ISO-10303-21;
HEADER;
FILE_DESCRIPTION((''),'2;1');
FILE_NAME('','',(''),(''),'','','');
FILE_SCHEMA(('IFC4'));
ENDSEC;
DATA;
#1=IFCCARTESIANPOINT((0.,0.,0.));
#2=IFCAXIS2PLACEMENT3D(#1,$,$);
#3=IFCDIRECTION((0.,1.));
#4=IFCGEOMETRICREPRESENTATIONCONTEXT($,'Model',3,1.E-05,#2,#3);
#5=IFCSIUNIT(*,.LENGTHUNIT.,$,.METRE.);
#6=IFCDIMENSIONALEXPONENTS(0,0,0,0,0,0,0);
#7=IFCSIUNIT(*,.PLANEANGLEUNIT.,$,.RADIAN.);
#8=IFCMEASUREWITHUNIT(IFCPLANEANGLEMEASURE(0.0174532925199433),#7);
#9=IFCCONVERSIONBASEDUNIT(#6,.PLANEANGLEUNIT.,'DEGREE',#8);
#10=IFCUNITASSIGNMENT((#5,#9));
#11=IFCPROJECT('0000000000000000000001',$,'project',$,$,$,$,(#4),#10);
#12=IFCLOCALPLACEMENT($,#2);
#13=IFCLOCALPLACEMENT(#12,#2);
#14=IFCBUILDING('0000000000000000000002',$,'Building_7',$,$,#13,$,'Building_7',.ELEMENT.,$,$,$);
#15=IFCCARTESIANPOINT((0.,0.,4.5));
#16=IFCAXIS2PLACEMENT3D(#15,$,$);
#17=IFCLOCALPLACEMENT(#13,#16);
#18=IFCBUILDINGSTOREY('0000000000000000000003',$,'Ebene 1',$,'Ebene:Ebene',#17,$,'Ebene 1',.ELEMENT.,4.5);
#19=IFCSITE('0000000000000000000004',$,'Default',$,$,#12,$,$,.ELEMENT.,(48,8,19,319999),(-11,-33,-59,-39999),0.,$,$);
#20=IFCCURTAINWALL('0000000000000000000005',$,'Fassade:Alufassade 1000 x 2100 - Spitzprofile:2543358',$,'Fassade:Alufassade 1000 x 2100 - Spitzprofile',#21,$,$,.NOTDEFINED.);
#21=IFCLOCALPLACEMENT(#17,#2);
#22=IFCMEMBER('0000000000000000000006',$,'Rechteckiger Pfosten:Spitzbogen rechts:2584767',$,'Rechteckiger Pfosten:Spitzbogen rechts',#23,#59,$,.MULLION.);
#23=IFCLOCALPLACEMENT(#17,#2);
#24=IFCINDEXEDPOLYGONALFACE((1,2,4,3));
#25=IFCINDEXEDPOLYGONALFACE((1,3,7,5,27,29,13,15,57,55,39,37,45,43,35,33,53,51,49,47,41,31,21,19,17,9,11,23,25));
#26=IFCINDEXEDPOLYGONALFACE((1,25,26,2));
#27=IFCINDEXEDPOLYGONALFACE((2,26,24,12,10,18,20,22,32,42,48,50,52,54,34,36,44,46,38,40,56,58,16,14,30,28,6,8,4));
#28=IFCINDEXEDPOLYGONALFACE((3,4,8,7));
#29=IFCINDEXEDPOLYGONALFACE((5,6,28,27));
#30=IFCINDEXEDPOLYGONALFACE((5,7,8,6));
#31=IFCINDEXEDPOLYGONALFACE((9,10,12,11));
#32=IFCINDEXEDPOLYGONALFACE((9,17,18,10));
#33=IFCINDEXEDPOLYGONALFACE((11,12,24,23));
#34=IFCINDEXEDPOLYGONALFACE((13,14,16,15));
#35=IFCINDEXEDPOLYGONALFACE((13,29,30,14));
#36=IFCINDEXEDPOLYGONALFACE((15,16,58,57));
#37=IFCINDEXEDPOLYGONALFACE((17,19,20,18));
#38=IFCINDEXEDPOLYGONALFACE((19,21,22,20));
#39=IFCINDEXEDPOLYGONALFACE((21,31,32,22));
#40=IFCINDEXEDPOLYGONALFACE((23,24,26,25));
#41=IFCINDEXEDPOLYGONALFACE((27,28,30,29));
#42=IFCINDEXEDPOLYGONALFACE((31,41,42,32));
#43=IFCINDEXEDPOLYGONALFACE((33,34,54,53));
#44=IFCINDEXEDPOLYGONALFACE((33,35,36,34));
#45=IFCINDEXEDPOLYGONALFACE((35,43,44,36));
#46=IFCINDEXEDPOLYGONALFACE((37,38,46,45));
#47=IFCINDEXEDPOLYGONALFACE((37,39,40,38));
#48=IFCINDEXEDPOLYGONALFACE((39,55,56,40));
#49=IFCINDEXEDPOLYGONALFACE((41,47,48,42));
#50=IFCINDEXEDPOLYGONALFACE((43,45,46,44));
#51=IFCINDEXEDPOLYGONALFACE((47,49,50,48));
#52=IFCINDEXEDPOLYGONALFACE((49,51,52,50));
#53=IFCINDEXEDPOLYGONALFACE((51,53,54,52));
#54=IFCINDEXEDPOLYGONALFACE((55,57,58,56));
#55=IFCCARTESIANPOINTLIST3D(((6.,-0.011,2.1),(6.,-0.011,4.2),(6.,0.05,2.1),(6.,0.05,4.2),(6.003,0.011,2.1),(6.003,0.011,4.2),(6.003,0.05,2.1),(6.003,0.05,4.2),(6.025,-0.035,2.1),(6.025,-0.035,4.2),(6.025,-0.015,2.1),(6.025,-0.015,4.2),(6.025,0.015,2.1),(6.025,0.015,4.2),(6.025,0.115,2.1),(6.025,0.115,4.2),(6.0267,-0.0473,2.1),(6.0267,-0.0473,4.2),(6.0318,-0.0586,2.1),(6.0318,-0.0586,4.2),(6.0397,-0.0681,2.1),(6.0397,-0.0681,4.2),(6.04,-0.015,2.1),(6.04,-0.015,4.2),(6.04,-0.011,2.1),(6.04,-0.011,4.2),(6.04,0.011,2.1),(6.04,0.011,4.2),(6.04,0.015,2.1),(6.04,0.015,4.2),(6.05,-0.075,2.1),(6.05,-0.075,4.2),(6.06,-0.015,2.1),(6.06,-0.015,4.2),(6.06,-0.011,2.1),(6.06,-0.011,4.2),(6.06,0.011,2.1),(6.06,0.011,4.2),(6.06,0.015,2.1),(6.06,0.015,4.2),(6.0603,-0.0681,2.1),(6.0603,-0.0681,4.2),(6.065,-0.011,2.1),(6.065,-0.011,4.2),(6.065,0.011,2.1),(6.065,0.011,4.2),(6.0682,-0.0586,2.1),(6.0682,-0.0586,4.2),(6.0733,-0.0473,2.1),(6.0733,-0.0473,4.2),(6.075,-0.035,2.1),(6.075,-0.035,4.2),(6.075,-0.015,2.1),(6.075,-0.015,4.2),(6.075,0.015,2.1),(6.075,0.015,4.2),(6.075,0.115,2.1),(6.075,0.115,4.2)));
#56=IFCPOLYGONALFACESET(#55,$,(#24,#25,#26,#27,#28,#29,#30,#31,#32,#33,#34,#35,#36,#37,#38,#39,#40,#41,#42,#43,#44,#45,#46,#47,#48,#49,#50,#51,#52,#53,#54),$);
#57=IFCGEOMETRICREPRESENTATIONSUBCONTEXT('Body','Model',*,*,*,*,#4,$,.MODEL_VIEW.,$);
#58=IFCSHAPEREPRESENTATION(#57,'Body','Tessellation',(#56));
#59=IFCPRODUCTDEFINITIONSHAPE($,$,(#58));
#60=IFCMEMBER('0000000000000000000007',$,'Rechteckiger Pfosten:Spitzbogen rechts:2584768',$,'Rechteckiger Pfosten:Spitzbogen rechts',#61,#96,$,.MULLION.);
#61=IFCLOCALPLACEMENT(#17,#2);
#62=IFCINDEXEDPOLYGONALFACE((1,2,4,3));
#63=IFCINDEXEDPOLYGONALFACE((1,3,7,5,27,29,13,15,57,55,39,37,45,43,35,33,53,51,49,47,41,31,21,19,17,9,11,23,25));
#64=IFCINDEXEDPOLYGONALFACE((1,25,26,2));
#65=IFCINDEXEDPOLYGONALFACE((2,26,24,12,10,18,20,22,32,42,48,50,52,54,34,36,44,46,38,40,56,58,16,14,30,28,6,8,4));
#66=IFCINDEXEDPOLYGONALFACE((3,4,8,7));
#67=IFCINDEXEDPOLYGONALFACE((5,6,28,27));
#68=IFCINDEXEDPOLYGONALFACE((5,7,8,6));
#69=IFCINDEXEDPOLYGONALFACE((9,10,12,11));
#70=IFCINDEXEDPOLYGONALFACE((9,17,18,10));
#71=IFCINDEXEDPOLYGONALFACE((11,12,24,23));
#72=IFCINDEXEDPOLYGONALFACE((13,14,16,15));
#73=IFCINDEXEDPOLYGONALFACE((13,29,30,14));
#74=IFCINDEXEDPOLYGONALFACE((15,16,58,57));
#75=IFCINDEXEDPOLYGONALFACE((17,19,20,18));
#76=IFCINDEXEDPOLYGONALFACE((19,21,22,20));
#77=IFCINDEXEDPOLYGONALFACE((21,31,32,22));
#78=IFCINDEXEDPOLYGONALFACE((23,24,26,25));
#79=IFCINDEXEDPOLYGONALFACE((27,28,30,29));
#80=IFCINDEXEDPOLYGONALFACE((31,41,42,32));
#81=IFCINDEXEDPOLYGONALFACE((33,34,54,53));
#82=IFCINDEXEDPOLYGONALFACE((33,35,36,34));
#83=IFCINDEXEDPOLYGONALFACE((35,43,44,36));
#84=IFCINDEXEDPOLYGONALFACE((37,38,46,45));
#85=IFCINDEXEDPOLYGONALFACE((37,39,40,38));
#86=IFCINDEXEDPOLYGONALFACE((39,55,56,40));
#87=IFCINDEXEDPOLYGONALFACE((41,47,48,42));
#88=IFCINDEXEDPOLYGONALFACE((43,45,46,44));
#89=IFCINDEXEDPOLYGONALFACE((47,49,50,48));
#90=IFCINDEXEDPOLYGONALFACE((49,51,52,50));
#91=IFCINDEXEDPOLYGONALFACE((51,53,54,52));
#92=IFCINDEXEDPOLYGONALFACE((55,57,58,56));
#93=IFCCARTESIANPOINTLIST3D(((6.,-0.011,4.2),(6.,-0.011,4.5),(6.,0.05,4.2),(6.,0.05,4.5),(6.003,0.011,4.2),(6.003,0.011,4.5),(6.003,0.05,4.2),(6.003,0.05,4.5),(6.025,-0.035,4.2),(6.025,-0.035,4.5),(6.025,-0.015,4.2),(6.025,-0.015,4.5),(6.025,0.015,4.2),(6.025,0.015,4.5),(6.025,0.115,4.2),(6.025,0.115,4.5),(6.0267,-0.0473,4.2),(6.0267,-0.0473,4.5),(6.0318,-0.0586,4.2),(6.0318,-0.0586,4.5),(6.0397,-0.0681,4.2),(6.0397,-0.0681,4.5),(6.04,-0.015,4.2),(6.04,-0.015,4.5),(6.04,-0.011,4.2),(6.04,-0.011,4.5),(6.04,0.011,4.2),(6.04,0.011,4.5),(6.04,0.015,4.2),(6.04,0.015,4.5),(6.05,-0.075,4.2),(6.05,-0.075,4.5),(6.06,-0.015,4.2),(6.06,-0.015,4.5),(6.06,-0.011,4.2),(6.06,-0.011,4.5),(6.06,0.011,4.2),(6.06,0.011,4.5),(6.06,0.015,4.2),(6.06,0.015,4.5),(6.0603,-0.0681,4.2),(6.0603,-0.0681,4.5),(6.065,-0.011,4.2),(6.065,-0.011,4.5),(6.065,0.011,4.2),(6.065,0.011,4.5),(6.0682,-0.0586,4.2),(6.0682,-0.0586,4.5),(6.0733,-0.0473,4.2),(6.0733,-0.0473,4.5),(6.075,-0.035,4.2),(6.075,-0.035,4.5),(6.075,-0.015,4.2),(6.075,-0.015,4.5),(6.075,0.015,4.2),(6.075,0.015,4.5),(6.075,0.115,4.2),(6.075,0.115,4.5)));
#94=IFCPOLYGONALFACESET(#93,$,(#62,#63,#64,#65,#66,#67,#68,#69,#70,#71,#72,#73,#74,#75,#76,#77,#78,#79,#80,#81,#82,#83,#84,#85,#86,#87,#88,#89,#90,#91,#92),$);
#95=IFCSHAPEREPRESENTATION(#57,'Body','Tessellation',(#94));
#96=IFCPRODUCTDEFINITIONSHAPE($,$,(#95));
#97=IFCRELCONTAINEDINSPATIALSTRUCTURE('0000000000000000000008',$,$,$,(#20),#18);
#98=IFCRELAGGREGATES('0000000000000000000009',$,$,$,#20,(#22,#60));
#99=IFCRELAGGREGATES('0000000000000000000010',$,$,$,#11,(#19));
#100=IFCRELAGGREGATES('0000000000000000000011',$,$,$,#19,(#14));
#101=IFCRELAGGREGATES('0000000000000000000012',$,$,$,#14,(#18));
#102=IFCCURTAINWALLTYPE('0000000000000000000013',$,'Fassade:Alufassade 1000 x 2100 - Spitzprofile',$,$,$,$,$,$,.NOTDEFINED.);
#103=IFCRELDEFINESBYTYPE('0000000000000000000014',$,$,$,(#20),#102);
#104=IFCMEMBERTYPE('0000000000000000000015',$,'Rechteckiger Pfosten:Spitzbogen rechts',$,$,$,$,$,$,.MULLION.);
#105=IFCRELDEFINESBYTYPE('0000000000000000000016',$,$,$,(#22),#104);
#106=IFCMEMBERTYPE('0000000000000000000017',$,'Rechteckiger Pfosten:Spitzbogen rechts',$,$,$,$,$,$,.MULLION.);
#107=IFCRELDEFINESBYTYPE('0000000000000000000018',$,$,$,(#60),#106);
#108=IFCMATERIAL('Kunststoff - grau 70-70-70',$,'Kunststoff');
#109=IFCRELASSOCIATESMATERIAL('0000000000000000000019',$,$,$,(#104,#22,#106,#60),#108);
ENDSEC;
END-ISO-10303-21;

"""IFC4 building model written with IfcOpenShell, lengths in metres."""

from ifc_helpers import new_model, entity, si_unit, converted_unit, direction, frame, origin, place, context, subcontext, project, spatial, line, arc, indexed_curve, outline, extrude, source, transform, mapped, material, type_object, type_shapes, element, aggregate, save


model = new_model("IFC4")

# Units and contexts
model_context = context("Model", 3, precision=1e-05, world=origin(), true_north=direction((0.0, 1.0)))
body_context = subcontext(model_context, "Body", "Model", "MODEL_VIEW")
ifc_project = project(units=[si_unit("LENGTHUNIT", "METRE"), converted_unit("PLANEANGLEUNIT", "DEGREE", entity("IfcPlaneAngleMeasure", 0.0174532925199433), si_unit("PLANEANGLEUNIT", "RADIAN"), dimensions=[0, 0, 0, 0, 0, 0, 0])], contexts=[model_context])

# Site, building, storey
site_placement = place(None, origin())
site = spatial("IfcSite", under=ifc_project, at=site_placement, Name="Default", CompositionType="ELEMENT", RefLatitude=(48, 8, 19, 319999), RefLongitude=(-11, -33, -59, -39999), RefElevation=0.0)
building_placement = place(site_placement, origin())
building = spatial("IfcBuilding", under=site, at=building_placement, Name="Building_7", LongName="Building_7", CompositionType="ELEMENT")
storey_placement = place(building_placement, frame((0.0, 0.0, 4.5)))
storey = spatial("IfcBuildingStorey", under=building, at=storey_placement, Name="Ebene 1", ObjectType="Ebene:Ebene", LongName="Ebene 1", CompositionType="ELEMENT", Elevation=4.5)

# Curtain wall, members
curtain_wall_type = type_object("IfcCurtainWallType", Name="Fassade:Alufassade 1000 x 2100 - Spitzprofile", PredefinedType="NOTDEFINED")
curtain_wall_placement = place(storey_placement, frame((0.0, 0.0, -4.5)))
curtain_wall = element("IfcCurtainWall", 1, at=curtain_wall_placement, inside=storey, type_object=curtain_wall_type, Name="Fassade:Alufassade 1000 x 2100 - Spitzprofile:2543358", ObjectType="Fassade:Alufassade 1000 x 2100 - Spitzprofile", PredefinedType="NOTDEFINED")
ifc_material = material(Name="Kunststoff - grau 70-70-70", Category="Kunststoff")
member_type_1 = type_object("IfcMemberType", Name="Rechteckiger Pfosten:Spitzbogen rechts", PredefinedType="MULLION", material=ifc_material)
shared_shape_1 = source(origin(), body_context, "Body", "SweptSolid", [
    extrude(outline(indexed_curve([(-0.107, -0.0321), (-0.007, -0.0321), (-0.007, -0.0171), (-0.003, -0.0171), (-0.003, -0.0221), (0.019, -0.0221), (0.019, -0.0171), (0.023, -0.0171), (0.023, -0.0321), (0.043, -0.0321), (0.0666, -0.0254), (0.083, -0.0071), (0.0666, 0.0111), (0.043, 0.0179), (0.023, 0.0179), (0.023, 0.0029), (0.019, 0.0029), (0.019, 0.0429), (-0.042, 0.0429), (-0.042, 0.0399), (-0.003, 0.0399), (-0.003, 0.0029), (-0.007, 0.0029), (-0.007, 0.0179), (-0.107, 0.0179)], segments=[line(1, 2, 3, 4, 5, 6, 7, 8, 9, 10), arc(10, 11, 12), arc(12, 13, 14), line(14, 15, 16, 17, 18, 19, 20, 21, 22, 23, 24, 25, 1)], self_intersect=False)), frame((-0.0429, 0.008, -2.1), z_axis=(0.0, 0.0, 1.0), x_axis=(0.0, -1.0, 0.0)), (0.0, 0.0, 1.0), 2.1),
])
type_shapes(member_type_1, [shared_shape_1])
member_1_placement = place(curtain_wall_placement, frame((6.0, 0.0, 6.6), z_axis=(0.0, 0.0, -1.0), x_axis=(-1.0, 0.0, 0.0)))
member_1 = element("IfcMember", 2, at=member_1_placement, type_object=member_type_1, material=ifc_material, Name="Rechteckiger Pfosten:Spitzbogen rechts:2584767", ObjectType="Rechteckiger Pfosten:Spitzbogen rechts", PredefinedType="MULLION", context=body_context, shape_type="MappedRepresentation", body=[
    mapped(shared_shape_1, transform((0.0, 0.0, 0.0), scale=1.0)),
])
member_type_2 = type_object("IfcMemberType", Name="Rechteckiger Pfosten:Spitzbogen rechts", PredefinedType="MULLION", material=ifc_material)
shared_shape_2 = source(origin(), body_context, "Body", "SweptSolid", [
    extrude(outline(indexed_curve([(-0.107, -0.0321), (-0.007, -0.0321), (-0.007, -0.0171), (-0.003, -0.0171), (-0.003, -0.0221), (0.019, -0.0221), (0.019, -0.0171), (0.023, -0.0171), (0.023, -0.0321), (0.043, -0.0321), (0.0666, -0.0254), (0.083, -0.0071), (0.0666, 0.0111), (0.043, 0.0179), (0.023, 0.0179), (0.023, 0.0029), (0.019, 0.0029), (0.019, 0.0429), (-0.042, 0.0429), (-0.042, 0.0399), (-0.003, 0.0399), (-0.003, 0.0029), (-0.007, 0.0029), (-0.007, 0.0179), (-0.107, 0.0179)], segments=[line(1, 2, 3, 4, 5, 6, 7, 8, 9, 10), arc(10, 11, 12), arc(12, 13, 14), line(14, 15, 16, 17, 18, 19, 20, 21, 22, 23, 24, 25, 1)], self_intersect=False)), frame((-0.0429, 0.008, -0.3), z_axis=(0.0, 0.0, 1.0), x_axis=(0.0, -1.0, 0.0)), (0.0, 0.0, 1.0), 0.3),
])
type_shapes(member_type_2, [shared_shape_2])
member_2_placement = place(curtain_wall_placement, frame((6.0, 0.0, 8.7), z_axis=(0.0, 0.0, -1.0), x_axis=(-1.0, 0.0, 0.0)))
member_2 = element("IfcMember", 3, at=member_2_placement, type_object=member_type_2, material=ifc_material, Name="Rechteckiger Pfosten:Spitzbogen rechts:2584768", ObjectType="Rechteckiger Pfosten:Spitzbogen rechts", PredefinedType="MULLION", context=body_context, shape_type="MappedRepresentation", body=[
    mapped(shared_shape_2, transform((0.0, 0.0, 0.0), scale=1.0)),
])
aggregate(curtain_wall, [member_1, member_2])

save(model, "model.ifc")
